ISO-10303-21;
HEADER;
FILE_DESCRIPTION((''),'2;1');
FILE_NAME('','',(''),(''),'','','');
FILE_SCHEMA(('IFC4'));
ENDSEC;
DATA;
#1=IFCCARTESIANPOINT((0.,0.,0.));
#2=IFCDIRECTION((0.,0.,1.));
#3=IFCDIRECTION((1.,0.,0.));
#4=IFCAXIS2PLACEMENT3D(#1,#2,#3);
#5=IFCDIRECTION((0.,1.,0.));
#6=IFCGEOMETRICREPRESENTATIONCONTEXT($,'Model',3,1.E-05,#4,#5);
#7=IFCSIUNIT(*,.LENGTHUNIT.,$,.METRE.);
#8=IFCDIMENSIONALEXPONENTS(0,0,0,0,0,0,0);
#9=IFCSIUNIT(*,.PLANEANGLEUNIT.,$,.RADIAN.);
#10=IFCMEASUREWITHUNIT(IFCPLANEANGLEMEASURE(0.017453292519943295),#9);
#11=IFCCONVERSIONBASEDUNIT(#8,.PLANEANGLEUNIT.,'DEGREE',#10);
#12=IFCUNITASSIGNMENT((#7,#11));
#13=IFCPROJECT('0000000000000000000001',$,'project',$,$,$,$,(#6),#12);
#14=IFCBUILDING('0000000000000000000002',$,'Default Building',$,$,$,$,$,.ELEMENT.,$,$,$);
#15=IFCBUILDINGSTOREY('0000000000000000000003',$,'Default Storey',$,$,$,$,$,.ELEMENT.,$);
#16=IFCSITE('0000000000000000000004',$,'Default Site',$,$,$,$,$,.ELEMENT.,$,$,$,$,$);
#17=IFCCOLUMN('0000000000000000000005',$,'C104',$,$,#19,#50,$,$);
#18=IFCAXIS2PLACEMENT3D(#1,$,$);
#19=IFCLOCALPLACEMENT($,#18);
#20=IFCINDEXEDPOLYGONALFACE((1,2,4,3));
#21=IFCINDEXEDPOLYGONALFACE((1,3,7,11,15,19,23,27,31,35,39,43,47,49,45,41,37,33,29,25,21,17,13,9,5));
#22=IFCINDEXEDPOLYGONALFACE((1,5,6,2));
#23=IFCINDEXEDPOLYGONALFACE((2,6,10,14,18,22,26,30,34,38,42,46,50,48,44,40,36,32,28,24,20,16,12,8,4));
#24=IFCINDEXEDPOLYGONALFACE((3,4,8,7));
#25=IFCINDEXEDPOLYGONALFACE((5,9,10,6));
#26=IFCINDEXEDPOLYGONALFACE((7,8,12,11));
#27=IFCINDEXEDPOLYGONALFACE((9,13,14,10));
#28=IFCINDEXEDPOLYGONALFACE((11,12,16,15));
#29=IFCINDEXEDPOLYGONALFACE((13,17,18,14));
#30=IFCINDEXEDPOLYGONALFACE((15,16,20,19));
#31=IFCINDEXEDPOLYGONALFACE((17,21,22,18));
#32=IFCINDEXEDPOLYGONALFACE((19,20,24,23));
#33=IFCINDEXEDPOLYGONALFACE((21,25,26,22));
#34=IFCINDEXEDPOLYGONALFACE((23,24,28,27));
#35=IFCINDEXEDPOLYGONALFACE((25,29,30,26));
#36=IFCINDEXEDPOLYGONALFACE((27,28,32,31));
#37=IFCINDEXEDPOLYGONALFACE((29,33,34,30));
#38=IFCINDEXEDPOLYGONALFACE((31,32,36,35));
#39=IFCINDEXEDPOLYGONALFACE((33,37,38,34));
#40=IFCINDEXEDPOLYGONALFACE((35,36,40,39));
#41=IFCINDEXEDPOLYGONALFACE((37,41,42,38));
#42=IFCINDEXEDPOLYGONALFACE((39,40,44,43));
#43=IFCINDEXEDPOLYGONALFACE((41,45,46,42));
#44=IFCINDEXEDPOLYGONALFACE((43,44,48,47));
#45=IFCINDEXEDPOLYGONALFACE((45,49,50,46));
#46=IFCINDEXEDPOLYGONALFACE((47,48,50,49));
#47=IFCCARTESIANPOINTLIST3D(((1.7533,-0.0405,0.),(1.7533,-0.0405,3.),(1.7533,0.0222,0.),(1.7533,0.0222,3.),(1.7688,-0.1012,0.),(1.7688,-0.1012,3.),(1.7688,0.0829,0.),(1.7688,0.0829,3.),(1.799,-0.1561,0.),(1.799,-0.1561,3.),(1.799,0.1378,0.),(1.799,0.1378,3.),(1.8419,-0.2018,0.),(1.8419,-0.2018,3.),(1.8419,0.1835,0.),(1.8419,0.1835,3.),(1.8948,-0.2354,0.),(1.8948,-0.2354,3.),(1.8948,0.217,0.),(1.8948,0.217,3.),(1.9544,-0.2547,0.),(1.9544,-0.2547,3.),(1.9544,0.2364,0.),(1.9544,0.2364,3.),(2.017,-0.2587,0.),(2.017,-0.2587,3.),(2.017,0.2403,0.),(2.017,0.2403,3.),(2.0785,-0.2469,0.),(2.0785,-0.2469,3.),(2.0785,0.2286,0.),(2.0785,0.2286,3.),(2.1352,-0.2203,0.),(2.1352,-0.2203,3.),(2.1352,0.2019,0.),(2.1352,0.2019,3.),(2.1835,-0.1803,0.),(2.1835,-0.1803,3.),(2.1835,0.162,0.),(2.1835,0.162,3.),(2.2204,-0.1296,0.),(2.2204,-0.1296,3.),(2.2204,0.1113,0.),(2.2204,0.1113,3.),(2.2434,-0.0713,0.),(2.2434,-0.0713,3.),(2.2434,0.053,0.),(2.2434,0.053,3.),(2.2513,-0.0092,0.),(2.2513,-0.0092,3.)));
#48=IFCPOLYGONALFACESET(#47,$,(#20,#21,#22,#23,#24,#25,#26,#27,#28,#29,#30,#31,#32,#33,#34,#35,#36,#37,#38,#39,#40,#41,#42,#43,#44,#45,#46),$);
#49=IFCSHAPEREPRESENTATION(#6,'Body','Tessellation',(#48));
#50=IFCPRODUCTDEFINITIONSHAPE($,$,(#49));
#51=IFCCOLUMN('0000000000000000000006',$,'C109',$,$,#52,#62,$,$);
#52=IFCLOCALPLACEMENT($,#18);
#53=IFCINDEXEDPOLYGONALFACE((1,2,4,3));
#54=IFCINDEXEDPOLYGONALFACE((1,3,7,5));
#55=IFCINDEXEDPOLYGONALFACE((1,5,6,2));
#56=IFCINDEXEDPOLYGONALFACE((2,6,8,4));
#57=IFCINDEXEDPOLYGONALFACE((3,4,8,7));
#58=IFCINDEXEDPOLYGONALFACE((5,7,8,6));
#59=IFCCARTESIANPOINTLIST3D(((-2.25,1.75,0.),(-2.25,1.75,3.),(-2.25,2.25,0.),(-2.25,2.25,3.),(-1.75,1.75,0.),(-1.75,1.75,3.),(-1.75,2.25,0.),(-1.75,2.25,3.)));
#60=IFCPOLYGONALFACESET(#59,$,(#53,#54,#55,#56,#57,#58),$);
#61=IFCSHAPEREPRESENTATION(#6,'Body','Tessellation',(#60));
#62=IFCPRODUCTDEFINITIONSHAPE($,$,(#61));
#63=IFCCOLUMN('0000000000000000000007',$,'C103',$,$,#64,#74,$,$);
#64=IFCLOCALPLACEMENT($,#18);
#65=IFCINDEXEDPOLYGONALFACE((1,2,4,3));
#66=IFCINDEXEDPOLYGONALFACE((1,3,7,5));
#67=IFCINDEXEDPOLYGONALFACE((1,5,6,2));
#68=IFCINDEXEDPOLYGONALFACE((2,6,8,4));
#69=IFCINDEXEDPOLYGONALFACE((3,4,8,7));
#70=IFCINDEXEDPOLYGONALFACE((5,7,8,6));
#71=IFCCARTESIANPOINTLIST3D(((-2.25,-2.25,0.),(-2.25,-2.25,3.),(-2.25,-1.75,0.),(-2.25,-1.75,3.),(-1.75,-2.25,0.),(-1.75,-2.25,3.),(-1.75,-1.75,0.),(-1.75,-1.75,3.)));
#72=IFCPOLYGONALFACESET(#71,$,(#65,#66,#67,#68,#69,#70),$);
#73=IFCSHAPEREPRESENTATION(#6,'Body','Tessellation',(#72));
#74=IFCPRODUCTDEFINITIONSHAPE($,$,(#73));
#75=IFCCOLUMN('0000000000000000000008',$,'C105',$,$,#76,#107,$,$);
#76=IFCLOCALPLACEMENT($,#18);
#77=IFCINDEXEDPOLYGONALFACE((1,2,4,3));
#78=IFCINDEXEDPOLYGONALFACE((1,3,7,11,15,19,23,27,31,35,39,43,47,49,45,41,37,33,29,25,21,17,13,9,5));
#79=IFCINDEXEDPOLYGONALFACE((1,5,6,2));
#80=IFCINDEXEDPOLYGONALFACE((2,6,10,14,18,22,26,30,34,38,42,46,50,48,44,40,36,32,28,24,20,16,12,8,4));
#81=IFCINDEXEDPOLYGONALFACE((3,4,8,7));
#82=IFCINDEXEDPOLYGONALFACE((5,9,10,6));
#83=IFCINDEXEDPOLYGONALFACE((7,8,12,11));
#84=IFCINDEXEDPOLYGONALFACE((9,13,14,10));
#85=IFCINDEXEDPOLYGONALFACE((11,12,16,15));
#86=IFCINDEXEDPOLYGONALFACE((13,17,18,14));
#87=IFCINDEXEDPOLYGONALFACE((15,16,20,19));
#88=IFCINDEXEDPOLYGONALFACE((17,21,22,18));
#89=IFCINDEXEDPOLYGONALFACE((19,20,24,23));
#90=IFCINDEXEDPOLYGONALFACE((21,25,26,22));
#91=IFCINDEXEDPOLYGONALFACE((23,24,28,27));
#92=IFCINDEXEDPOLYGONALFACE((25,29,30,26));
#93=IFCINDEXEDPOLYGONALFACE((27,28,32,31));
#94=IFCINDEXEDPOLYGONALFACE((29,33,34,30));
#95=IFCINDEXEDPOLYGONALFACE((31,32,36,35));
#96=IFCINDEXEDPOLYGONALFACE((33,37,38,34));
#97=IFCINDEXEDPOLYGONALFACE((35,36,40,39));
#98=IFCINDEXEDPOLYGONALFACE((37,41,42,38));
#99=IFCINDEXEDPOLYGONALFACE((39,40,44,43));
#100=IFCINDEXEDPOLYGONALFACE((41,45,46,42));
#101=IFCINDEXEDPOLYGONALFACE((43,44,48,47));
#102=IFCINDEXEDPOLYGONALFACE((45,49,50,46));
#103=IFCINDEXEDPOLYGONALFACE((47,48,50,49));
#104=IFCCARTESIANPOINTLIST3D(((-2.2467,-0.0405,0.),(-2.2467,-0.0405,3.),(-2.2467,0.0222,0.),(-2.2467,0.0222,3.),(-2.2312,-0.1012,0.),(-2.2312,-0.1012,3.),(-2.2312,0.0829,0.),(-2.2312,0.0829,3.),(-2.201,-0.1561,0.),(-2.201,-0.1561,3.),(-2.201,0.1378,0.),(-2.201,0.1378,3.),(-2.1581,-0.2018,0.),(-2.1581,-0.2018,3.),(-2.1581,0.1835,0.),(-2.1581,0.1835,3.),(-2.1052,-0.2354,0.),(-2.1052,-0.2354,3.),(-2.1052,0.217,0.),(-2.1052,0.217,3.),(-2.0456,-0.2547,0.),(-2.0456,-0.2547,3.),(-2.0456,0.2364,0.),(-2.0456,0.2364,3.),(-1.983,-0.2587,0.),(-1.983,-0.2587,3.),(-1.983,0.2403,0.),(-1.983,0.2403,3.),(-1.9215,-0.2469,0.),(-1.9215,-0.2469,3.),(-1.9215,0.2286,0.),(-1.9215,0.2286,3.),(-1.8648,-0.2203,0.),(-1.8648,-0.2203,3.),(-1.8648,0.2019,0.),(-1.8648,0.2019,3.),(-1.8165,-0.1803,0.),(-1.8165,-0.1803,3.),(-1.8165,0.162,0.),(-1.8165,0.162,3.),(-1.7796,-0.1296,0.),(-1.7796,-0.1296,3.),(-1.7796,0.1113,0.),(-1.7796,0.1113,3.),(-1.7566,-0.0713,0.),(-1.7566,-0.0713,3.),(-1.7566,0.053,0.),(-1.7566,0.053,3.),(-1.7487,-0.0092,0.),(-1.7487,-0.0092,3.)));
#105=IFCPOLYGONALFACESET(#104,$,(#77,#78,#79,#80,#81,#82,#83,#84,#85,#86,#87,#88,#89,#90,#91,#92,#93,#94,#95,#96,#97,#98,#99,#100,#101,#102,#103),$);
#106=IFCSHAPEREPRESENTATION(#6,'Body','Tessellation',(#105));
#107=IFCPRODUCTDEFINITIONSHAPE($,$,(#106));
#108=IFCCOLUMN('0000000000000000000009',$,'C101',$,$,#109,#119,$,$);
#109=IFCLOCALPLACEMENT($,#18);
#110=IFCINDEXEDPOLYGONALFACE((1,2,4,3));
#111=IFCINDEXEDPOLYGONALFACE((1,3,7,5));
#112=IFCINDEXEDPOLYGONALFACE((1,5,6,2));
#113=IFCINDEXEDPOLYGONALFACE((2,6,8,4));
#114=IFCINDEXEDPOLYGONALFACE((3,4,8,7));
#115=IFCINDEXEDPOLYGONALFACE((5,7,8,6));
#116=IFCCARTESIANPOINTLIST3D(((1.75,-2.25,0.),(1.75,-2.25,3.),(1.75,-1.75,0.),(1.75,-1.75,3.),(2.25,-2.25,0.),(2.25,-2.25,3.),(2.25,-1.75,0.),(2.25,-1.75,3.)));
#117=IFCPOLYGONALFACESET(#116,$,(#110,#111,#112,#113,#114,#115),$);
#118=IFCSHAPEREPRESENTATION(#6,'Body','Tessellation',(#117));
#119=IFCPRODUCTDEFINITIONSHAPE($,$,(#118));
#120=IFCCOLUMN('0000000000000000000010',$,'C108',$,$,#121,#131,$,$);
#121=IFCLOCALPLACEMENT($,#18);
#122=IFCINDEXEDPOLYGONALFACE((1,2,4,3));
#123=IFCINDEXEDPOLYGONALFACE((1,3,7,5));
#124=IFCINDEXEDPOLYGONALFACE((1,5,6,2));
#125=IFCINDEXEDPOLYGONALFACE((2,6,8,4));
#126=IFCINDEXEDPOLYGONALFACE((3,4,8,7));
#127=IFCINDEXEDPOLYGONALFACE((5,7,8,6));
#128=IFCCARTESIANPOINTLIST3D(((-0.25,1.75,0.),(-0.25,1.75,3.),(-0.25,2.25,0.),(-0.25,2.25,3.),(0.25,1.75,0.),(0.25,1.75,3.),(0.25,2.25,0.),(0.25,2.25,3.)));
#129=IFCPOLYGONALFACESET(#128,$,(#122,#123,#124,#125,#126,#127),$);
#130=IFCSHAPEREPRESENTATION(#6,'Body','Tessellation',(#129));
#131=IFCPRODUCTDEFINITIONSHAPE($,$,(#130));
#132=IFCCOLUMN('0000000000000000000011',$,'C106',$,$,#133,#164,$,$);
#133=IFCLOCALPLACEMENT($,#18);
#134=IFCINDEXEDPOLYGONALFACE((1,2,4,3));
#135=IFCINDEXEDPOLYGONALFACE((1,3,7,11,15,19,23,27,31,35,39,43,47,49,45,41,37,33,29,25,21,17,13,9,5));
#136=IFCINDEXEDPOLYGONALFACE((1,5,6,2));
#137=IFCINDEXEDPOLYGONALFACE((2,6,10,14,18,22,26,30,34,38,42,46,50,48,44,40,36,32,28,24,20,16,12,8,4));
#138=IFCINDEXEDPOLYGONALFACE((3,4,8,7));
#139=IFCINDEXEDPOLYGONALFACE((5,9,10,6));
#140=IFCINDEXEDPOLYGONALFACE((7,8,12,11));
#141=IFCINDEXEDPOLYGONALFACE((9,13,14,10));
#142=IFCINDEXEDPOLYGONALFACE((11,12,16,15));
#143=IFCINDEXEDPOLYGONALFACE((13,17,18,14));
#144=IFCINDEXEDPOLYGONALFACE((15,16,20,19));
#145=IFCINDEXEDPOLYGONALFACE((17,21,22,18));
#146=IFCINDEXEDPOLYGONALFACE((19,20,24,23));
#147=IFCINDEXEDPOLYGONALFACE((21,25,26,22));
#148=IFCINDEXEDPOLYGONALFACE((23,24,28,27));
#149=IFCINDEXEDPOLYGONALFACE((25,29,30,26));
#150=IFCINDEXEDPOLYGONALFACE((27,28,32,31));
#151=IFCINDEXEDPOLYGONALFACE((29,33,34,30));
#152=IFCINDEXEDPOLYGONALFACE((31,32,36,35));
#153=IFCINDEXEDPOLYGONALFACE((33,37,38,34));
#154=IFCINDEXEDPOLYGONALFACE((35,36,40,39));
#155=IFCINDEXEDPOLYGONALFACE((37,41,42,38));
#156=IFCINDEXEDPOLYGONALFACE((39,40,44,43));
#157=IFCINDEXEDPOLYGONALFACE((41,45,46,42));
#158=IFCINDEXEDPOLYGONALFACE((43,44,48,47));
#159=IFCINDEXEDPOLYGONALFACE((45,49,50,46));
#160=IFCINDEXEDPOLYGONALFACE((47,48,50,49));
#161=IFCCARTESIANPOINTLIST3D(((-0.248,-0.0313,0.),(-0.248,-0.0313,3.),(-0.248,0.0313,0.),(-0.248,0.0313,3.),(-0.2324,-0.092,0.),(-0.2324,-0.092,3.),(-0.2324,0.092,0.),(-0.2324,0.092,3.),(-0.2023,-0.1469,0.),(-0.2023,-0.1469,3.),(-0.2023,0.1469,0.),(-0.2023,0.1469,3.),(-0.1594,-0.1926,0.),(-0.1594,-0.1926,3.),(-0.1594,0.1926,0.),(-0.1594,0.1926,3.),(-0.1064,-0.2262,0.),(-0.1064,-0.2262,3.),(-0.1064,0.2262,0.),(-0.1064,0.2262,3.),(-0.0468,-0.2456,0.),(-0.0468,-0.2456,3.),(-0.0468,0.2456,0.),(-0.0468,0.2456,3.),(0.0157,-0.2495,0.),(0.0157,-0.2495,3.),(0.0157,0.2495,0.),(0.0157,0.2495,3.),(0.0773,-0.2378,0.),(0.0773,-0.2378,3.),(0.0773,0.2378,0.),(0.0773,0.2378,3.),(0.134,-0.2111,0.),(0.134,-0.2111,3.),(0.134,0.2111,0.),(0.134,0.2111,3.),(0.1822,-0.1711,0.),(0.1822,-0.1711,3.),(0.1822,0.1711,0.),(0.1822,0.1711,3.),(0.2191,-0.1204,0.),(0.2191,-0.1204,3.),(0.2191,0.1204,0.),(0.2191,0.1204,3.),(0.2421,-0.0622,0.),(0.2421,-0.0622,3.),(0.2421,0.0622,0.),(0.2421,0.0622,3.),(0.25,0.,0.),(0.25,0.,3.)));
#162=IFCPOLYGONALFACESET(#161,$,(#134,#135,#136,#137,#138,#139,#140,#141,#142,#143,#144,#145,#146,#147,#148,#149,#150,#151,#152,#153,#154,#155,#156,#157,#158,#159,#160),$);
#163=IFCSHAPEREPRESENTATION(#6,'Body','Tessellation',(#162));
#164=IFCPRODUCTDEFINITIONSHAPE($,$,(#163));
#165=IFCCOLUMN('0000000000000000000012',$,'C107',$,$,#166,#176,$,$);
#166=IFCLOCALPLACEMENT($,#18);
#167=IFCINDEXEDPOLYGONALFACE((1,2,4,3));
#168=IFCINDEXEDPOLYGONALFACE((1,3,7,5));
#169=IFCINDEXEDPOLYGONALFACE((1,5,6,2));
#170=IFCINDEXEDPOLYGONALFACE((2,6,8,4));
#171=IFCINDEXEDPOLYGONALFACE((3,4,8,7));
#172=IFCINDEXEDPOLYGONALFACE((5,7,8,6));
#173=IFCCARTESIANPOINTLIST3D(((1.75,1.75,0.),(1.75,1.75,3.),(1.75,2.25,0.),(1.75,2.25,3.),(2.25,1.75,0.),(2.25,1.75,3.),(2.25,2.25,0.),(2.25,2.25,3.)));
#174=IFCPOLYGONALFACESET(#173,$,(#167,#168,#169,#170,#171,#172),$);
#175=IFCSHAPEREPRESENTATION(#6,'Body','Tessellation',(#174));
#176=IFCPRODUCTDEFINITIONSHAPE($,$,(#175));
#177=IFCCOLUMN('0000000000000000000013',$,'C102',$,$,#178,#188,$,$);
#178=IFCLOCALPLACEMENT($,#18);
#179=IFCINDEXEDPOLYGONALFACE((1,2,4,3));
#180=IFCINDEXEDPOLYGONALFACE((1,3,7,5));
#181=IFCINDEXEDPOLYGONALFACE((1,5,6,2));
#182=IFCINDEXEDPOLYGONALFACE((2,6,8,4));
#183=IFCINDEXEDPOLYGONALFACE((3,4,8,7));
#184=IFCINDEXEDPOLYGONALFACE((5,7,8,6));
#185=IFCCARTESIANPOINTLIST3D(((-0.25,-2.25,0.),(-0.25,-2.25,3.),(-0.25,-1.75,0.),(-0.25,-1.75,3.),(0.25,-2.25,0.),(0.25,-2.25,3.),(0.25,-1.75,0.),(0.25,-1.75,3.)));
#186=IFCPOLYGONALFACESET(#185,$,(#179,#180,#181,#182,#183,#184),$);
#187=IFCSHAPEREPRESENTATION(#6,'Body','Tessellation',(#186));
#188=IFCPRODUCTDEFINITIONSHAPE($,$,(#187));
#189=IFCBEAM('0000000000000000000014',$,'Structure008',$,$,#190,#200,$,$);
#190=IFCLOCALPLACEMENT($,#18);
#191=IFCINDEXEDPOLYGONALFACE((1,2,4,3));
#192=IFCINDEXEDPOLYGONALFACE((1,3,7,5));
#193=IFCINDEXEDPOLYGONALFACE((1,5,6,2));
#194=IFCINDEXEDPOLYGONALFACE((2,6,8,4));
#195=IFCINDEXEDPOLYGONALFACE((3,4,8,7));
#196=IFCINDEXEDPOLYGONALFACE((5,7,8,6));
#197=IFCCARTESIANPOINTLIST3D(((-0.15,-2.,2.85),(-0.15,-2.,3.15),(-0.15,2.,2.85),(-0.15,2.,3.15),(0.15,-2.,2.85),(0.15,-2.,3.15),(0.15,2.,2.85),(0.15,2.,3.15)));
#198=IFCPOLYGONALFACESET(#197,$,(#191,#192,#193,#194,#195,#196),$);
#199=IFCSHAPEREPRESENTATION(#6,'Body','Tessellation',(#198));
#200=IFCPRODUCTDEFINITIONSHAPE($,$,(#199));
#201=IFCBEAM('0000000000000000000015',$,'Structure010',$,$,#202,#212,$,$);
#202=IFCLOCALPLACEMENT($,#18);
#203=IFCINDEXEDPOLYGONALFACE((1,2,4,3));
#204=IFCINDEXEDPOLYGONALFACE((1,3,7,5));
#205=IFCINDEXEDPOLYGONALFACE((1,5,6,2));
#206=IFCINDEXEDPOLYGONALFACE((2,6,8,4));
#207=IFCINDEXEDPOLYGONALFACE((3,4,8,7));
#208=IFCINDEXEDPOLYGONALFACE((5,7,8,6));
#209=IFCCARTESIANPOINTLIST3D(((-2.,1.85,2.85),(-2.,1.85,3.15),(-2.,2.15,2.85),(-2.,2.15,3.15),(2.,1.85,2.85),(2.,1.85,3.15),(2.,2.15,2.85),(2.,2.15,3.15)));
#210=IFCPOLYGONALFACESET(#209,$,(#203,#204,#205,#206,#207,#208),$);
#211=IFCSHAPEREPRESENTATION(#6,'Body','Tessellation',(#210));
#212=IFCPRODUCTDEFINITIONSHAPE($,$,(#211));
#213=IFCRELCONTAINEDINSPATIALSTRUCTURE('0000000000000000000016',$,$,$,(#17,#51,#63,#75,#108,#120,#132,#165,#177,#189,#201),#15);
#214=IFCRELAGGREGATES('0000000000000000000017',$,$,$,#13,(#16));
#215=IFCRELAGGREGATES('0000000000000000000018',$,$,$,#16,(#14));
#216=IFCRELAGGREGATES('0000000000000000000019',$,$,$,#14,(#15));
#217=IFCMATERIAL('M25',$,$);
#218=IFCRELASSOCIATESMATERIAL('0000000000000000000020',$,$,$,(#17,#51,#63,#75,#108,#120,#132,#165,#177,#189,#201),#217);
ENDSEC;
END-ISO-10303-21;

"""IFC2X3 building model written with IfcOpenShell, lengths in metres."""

from ifc_helpers import new_model, entity, si_unit, converted_unit, direction, frame, frame_2d, origin_with_axes, origin_2d_with_axis, place, context, project, spatial, rectangle, circle, extrude, material, element, save


model = new_model("IFC2X3")

# Units and contexts
model_context = context("Model", 3, precision=1e-05, world=origin_with_axes(), true_north=direction((0.0, 1.0, 0.0)))
ifc_project = project(units=[si_unit("LENGTHUNIT", "METRE"), converted_unit("PLANEANGLEUNIT", "DEGREE", entity("IfcPlaneAngleMeasure", 0.017453292519943295), si_unit("PLANEANGLEUNIT", "RADIAN"), dimensions=[0, 0, 0, 0, 0, 0, 0])], contexts=[model_context])

# Site, building, storey
site = spatial("IfcSite", under=ifc_project, Name="Default Site", CompositionType="ELEMENT")
building = spatial("IfcBuilding", under=site, Name="Default Building", CompositionType="ELEMENT")
storey = spatial("IfcBuildingStorey", under=building, Name="Default Storey", CompositionType="ELEMENT")

# Columns
ifc_material = material(Name="M25")
placement = place(None, origin_with_axes())
element("IfcColumn", 1, at=placement, inside=storey, material=ifc_material, Name="C104", context=model_context, shape_type="SweptSolid", body=[
    extrude(circle(Radius=0.25, at=origin_2d_with_axis()), frame((2.0013, -0.0092, 0.0), z_axis=(0.0, 0.0, 1.0), x_axis=(1.0, 0.0, 0.0)), (0.0, 0.0, 1.0), 3.0),
])
element("IfcColumn", 2, at=placement, inside=storey, material=ifc_material, Name="C109", context=model_context, shape_type="SweptSolid", body=[
    extrude(rectangle(XDim=0.5, YDim=0.5, at=frame_2d((0.0, 0.0), x_axis=(1.0, 0.0, 0.0))), frame((-2.0, 2.0, 0.0), z_axis=(0.0, 0.0, 1.0), x_axis=(1.0, 0.0, 0.0)), (0.0, 0.0, 1.0), 3.0),
])
element("IfcColumn", 3, at=placement, inside=storey, material=ifc_material, Name="C103", context=model_context, shape_type="SweptSolid", body=[
    extrude(rectangle(XDim=0.5, YDim=0.5, at=frame_2d((0.0, 0.0), x_axis=(1.0, 0.0, 0.0))), frame((-2.0, -2.0, 0.0), z_axis=(0.0, 0.0, 1.0), x_axis=(1.0, 0.0, 0.0)), (0.0, 0.0, 1.0), 3.0),
])
element("IfcColumn", 4, at=placement, inside=storey, material=ifc_material, Name="C105", context=model_context, shape_type="SweptSolid", body=[
    extrude(circle(Radius=0.25, at=origin_2d_with_axis()), frame((-1.9987, -0.0092, 0.0), z_axis=(0.0, 0.0, 1.0), x_axis=(1.0, 0.0, 0.0)), (0.0, 0.0, 1.0), 3.0),
])
element("IfcColumn", 5, at=placement, inside=storey, material=ifc_material, Name="C101", context=model_context, shape_type="SweptSolid", body=[
    extrude(rectangle(XDim=0.5, YDim=0.5, at=frame_2d((0.0, 0.0), x_axis=(1.0, 0.0, 0.0))), frame((2.0, -2.0, 0.0), z_axis=(0.0, 0.0, 1.0), x_axis=(1.0, 0.0, 0.0)), (0.0, 0.0, 1.0), 3.0),
])
element("IfcColumn", 6, at=placement, inside=storey, material=ifc_material, Name="C108", context=model_context, shape_type="SweptSolid", body=[
    extrude(rectangle(XDim=0.5, YDim=0.5, at=frame_2d((0.0, 0.0), x_axis=(1.0, 0.0, 0.0))), frame((0.0, 2.0, 0.0), z_axis=(0.0, 0.0, 1.0), x_axis=(1.0, 0.0, 0.0)), (0.0, 0.0, 1.0), 3.0),
])
element("IfcColumn", 7, at=placement, inside=storey, material=ifc_material, Name="C106", context=model_context, shape_type="SweptSolid", body=[
    extrude(circle(Radius=0.25, at=origin_2d_with_axis()), frame((0.0, 0.0, 0.0), z_axis=(0.0, 0.0, 1.0), x_axis=(1.0, 0.0, 0.0)), (0.0, 0.0, 1.0), 3.0),
])
element("IfcColumn", 8, at=placement, inside=storey, material=ifc_material, Name="C107", context=model_context, shape_type="SweptSolid", body=[
    extrude(rectangle(XDim=0.5, YDim=0.5, at=frame_2d((0.0, 0.0), x_axis=(1.0, 0.0, 0.0))), frame((2.0, 2.0, 0.0), z_axis=(0.0, 0.0, 1.0), x_axis=(1.0, 0.0, 0.0)), (0.0, 0.0, 1.0), 3.0),
])
element("IfcColumn", 9, at=placement, inside=storey, material=ifc_material, Name="C102", context=model_context, shape_type="SweptSolid", body=[
    extrude(rectangle(XDim=0.5, YDim=0.5, at=frame_2d((0.0, 0.0), x_axis=(1.0, 0.0, 0.0))), frame((0.0, -2.0, 0.0), z_axis=(0.0, 0.0, 1.0), x_axis=(1.0, 0.0, 0.0)), (0.0, 0.0, 1.0), 3.0),
])

# Beams
element("IfcBeam", 10, at=placement, inside=storey, material=ifc_material, Name="Structure008", context=model_context, shape_type="SweptSolid", body=[
    extrude(rectangle(XDim=0.3, YDim=0.3, at=frame_2d((0.0, 0.0), x_axis=(0.0, 1.0, 0.0))), frame((0.0, 2.0, 3.0), z_axis=(0.0, -1.0, 0.0), x_axis=(0.0, 0.0, -1.0)), (0.0, 0.0, 1.0), 4.0),
])
element("IfcBeam", 11, at=placement, inside=storey, material=ifc_material, Name="Structure010", context=model_context, shape_type="SweptSolid", body=[
    extrude(rectangle(XDim=0.3, YDim=0.3, at=frame_2d((0.0, 0.0), x_axis=(0.0, 1.0, 0.0))), frame((2.0, 2.0, 3.0), z_axis=(-1.0, 0.0, 0.0), x_axis=(0.0, 0.0, -1.0)), (0.0, 0.0, 1.0), 4.0),
])

save(model, "model.ifc")
